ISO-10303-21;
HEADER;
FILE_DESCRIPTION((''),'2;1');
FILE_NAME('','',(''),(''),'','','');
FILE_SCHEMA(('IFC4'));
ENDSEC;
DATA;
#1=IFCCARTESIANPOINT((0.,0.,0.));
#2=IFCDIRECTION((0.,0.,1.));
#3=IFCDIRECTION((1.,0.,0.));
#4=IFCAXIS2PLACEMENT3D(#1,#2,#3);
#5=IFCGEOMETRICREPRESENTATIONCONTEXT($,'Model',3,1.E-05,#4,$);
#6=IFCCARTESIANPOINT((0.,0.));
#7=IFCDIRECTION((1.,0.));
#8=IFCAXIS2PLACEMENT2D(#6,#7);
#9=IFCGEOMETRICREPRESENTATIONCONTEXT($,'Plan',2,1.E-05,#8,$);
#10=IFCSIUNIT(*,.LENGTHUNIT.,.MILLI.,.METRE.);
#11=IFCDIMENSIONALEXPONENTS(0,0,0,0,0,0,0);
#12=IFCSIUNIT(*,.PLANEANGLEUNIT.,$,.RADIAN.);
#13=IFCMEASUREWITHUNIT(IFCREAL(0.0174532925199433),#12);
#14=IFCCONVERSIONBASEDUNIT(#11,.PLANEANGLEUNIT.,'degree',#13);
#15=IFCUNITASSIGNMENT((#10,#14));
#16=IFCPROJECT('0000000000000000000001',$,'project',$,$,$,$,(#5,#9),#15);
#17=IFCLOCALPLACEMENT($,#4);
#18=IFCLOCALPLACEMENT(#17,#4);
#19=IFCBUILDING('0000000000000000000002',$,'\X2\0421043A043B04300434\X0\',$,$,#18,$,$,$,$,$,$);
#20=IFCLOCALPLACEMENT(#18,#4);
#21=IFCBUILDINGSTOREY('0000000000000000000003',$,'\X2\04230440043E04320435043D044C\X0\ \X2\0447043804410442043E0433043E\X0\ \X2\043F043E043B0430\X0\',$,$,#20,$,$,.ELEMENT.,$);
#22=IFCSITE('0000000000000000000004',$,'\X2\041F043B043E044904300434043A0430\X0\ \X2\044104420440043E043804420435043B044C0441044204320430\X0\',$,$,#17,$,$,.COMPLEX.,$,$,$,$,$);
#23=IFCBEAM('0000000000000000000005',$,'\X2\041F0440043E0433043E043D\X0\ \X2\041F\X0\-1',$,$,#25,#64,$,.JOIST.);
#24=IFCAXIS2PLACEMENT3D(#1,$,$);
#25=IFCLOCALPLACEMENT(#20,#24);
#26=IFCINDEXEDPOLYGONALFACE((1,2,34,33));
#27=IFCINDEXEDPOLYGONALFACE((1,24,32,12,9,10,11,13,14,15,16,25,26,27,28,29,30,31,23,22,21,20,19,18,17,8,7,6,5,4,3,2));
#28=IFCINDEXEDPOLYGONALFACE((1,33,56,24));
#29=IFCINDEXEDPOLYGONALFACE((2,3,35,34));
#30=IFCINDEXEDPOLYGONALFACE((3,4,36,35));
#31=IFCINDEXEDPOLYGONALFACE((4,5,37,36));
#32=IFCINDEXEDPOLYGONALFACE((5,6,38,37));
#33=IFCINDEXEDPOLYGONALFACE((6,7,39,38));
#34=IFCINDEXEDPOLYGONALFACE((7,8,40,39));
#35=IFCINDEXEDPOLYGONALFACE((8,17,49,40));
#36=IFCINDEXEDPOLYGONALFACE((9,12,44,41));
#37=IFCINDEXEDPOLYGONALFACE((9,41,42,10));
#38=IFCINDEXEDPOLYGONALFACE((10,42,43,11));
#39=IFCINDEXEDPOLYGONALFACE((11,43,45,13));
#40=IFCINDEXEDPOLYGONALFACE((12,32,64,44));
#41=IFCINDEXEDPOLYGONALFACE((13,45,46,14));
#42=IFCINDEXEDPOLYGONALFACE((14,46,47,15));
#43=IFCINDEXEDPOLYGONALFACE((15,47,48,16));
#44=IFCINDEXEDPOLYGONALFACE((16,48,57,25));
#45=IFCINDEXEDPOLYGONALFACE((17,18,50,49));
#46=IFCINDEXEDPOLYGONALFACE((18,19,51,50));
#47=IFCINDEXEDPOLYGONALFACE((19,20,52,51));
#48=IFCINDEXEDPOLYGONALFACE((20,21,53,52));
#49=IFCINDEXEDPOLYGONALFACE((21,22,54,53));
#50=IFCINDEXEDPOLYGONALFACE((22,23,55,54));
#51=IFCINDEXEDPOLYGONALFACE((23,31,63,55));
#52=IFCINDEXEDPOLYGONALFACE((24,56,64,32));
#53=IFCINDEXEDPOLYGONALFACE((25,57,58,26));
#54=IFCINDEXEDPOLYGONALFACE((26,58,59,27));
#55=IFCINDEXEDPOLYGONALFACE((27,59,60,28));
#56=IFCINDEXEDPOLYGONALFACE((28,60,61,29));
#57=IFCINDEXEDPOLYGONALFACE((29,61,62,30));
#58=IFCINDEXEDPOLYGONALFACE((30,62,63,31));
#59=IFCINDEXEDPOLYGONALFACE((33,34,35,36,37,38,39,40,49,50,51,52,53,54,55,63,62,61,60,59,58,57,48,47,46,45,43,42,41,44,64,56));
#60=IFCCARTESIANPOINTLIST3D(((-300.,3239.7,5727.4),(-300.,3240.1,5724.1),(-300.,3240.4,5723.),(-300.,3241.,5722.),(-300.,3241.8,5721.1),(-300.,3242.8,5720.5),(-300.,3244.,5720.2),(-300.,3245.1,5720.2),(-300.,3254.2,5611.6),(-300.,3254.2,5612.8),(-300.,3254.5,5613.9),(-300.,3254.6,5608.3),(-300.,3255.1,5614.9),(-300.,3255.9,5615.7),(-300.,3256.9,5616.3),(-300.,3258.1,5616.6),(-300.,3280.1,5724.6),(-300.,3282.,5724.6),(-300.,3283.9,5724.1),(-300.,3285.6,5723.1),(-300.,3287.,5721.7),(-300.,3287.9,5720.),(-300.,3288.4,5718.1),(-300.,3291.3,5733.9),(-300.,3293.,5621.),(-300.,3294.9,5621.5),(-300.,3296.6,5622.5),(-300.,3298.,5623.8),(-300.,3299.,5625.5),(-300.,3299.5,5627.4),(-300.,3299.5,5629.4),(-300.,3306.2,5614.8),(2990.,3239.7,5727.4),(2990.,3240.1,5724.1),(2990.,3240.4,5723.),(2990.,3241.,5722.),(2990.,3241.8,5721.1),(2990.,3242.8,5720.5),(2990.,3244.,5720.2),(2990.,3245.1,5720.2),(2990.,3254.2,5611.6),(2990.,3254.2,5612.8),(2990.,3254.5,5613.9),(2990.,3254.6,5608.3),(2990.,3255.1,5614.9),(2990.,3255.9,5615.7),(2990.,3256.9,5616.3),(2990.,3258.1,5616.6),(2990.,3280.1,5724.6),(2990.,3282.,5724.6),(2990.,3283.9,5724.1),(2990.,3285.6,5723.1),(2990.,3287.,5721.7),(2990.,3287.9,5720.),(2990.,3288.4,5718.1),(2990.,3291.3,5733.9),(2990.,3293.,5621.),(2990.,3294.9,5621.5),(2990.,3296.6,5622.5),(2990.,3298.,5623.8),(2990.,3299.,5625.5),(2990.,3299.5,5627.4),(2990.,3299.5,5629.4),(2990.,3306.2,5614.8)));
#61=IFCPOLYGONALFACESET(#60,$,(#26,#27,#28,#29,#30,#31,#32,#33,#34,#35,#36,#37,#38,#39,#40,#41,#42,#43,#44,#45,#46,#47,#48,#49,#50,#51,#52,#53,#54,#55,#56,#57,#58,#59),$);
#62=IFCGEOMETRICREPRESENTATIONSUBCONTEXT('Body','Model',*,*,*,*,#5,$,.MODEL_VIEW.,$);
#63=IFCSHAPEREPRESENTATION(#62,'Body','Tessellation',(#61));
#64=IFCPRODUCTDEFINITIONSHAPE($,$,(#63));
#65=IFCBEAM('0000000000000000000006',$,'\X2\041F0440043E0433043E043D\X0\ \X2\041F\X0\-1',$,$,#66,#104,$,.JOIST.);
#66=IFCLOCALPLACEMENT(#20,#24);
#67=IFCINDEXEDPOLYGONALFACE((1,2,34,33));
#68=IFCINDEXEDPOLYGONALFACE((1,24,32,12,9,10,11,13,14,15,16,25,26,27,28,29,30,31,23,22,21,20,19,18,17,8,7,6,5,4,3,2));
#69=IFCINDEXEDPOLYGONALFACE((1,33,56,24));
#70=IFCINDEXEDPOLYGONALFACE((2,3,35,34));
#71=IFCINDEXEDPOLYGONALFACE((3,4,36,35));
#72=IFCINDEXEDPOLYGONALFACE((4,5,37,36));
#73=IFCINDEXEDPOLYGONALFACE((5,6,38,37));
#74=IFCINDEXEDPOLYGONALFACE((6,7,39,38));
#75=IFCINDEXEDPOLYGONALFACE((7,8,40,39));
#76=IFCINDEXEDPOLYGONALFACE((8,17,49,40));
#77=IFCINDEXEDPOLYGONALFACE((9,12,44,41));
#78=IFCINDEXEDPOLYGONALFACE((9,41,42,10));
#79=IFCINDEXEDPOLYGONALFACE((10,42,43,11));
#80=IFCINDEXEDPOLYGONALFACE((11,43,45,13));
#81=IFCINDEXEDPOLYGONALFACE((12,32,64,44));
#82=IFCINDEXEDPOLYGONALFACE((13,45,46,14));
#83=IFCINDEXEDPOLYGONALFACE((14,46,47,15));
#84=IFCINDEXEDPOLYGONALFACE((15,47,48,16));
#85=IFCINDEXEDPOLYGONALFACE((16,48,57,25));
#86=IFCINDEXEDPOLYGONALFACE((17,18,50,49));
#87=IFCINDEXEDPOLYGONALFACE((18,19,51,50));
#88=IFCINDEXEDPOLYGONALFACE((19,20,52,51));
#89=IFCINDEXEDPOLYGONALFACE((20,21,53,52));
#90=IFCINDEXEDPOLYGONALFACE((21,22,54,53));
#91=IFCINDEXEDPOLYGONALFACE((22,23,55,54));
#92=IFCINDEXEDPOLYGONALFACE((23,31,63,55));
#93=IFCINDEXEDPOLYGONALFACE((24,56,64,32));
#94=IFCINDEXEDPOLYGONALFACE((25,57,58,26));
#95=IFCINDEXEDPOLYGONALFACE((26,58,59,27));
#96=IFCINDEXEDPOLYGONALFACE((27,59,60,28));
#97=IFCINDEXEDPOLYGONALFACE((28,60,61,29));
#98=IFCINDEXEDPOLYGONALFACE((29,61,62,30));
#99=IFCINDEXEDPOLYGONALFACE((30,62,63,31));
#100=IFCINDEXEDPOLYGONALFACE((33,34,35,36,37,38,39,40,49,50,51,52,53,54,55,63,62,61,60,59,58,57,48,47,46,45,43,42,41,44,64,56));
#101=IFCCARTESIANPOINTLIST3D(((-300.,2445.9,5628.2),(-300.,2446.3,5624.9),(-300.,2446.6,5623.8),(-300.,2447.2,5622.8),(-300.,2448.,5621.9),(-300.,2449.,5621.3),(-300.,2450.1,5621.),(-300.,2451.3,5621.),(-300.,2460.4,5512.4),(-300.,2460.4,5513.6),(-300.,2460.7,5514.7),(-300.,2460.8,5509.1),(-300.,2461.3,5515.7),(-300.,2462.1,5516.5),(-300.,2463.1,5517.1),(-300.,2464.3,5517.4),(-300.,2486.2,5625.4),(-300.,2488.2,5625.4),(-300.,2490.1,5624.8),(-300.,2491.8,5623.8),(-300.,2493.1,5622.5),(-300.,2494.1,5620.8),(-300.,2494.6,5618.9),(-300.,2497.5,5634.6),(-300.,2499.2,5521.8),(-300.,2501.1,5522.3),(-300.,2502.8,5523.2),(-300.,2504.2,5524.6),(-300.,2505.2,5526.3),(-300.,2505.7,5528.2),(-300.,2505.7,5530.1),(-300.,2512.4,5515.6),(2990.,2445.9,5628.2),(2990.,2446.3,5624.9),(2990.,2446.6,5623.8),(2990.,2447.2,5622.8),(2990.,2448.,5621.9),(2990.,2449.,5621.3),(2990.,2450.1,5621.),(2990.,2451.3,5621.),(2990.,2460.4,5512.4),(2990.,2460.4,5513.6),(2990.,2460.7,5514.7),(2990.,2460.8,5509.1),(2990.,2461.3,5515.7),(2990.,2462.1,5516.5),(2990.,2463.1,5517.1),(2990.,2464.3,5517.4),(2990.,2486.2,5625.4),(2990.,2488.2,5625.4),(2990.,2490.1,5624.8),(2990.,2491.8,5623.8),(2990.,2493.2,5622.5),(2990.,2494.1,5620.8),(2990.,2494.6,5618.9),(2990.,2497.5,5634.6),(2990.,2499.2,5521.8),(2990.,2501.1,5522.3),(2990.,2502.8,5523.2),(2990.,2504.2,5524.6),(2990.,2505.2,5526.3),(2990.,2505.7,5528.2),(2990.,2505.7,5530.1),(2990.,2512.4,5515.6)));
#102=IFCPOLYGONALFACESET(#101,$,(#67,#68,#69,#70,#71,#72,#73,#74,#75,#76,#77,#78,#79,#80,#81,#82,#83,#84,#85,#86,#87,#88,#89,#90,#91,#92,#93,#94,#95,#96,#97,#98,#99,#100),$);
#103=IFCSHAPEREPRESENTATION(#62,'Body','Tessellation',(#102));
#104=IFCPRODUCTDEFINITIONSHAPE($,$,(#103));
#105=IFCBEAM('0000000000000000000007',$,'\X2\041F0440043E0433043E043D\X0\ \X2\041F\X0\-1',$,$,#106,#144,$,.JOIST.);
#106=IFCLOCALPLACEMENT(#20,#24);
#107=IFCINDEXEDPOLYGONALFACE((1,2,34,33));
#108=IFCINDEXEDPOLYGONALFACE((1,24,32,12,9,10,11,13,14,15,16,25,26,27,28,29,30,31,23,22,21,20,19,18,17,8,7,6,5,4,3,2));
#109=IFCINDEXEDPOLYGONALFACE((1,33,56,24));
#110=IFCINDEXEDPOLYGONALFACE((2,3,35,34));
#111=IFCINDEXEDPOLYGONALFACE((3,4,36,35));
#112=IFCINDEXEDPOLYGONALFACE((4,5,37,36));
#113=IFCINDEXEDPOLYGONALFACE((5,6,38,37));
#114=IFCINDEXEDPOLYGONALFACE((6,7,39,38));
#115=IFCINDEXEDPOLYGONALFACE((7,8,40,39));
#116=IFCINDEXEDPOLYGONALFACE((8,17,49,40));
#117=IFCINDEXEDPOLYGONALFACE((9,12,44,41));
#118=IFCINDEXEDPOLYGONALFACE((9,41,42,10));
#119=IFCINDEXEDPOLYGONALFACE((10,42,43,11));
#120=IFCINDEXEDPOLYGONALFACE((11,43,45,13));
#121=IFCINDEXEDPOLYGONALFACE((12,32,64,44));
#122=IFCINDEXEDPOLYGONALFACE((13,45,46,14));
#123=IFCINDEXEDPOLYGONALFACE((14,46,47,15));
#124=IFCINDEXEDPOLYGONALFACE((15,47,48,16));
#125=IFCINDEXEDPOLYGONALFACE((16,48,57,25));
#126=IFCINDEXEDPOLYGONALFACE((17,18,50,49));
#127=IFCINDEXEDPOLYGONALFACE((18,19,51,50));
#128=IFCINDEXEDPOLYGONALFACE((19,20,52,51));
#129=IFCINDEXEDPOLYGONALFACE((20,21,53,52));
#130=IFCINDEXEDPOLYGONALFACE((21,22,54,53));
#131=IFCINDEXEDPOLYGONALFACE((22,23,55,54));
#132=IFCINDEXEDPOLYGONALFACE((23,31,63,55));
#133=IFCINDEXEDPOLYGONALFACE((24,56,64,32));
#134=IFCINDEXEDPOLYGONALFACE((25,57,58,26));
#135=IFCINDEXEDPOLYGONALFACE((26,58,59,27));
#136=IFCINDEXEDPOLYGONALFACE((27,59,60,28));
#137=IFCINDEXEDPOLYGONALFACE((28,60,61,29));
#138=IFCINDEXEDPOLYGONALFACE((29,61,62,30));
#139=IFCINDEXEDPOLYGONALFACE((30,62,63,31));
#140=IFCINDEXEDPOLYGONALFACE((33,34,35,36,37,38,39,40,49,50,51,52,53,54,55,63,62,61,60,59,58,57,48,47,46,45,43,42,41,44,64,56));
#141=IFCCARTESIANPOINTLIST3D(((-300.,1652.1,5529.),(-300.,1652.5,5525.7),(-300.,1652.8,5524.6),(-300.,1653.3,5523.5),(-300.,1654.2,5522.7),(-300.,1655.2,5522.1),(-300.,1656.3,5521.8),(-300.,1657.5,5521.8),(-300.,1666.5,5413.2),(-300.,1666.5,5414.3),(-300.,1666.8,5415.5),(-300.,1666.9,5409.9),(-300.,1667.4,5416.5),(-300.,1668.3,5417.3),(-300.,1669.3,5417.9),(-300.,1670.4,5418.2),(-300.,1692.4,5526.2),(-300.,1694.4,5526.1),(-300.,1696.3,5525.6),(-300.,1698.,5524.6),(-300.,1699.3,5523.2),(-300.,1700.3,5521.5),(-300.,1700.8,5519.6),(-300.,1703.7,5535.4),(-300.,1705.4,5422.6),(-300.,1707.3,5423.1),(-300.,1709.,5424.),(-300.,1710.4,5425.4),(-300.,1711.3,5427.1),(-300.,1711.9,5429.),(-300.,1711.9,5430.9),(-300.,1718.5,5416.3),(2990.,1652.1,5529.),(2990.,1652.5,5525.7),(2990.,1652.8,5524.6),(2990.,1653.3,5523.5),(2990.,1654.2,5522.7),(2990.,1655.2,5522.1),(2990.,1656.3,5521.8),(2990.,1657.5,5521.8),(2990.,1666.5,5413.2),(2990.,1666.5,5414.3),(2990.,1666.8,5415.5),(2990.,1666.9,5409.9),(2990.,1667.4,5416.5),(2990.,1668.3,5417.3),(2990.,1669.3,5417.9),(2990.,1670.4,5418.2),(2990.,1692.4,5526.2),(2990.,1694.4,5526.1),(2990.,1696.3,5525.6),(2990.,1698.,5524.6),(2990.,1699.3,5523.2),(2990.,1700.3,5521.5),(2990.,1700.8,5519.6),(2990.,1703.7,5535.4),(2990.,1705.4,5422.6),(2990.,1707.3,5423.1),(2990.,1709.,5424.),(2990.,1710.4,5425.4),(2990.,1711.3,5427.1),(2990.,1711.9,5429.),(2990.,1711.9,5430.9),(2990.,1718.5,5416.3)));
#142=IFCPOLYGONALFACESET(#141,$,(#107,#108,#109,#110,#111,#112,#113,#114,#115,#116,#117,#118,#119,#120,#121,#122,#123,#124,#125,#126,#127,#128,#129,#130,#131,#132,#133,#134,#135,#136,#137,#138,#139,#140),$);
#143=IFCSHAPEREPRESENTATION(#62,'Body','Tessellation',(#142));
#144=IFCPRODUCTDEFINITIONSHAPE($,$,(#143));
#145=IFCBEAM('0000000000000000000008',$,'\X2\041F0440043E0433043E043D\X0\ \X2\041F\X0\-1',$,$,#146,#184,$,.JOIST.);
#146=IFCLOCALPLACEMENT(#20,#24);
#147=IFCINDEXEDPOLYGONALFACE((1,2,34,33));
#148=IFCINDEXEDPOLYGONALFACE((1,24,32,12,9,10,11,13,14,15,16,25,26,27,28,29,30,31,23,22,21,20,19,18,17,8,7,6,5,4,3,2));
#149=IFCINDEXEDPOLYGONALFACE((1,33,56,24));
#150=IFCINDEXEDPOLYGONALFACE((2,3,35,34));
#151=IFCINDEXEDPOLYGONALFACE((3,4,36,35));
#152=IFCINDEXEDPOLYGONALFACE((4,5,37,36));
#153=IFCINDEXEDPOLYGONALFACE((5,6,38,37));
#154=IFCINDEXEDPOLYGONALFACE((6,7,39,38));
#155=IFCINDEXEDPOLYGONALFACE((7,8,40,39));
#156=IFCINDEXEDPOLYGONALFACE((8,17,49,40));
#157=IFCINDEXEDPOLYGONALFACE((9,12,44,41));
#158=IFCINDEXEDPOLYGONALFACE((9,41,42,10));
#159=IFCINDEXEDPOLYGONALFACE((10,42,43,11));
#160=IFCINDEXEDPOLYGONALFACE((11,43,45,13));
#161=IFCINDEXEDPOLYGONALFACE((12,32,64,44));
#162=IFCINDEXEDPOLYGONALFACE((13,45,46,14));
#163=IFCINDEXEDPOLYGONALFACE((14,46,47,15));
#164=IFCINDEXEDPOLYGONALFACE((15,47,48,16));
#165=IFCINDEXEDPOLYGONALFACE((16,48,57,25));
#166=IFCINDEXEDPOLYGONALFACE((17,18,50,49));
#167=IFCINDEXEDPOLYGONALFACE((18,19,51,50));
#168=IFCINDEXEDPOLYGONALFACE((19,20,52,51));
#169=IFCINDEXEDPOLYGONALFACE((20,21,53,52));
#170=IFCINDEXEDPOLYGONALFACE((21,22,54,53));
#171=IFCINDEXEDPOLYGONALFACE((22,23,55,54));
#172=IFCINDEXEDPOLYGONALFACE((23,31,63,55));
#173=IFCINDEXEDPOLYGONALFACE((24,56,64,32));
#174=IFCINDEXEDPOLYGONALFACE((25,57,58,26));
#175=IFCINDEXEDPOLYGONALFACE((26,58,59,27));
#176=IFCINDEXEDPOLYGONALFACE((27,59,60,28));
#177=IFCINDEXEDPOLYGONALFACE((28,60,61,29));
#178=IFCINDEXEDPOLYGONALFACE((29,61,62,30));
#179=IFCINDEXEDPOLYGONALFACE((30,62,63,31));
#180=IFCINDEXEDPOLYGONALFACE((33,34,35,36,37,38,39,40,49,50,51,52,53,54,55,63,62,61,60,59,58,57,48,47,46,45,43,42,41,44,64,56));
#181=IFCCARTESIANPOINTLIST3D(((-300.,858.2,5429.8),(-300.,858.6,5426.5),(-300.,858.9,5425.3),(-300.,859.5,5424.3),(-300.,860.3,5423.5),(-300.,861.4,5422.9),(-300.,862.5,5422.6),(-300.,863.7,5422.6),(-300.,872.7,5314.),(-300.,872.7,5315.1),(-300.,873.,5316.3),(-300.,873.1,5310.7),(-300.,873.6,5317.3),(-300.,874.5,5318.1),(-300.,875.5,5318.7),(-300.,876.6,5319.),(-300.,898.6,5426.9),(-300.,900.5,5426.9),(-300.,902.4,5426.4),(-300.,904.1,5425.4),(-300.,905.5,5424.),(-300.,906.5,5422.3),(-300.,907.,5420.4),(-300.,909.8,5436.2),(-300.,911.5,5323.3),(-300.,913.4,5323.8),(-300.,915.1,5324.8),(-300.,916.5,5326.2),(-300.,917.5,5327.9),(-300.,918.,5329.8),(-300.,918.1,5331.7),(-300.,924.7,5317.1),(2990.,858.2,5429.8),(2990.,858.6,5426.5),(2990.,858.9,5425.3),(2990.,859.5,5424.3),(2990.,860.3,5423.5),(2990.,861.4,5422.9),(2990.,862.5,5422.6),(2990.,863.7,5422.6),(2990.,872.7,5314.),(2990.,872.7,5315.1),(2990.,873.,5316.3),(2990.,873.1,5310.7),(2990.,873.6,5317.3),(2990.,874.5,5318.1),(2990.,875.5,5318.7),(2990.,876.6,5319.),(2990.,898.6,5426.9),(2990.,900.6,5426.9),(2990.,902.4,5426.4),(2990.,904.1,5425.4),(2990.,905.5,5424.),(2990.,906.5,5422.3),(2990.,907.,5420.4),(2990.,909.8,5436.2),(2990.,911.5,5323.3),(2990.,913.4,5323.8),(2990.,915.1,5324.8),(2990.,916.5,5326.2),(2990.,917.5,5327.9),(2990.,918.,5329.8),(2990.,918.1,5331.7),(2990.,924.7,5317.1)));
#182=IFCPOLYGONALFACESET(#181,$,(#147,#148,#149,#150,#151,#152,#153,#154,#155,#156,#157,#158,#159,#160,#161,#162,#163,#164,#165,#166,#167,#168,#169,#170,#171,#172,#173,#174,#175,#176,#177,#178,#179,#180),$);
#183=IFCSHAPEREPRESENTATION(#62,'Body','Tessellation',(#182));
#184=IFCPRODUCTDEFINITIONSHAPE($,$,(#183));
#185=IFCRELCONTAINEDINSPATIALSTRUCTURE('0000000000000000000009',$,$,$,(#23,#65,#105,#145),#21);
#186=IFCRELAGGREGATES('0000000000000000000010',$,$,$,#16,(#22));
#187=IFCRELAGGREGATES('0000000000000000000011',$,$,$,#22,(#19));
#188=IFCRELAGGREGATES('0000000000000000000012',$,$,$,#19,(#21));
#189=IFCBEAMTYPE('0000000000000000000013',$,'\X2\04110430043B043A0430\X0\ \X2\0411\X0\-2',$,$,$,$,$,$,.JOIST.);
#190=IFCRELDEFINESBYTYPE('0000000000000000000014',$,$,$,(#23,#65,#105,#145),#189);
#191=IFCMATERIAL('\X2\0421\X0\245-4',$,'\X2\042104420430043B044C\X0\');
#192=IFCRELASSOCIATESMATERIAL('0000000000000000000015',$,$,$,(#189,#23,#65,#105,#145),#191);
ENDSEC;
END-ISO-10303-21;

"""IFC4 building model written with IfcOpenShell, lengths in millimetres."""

from ifc_helpers import new_model, entity, si_unit, converted_unit, frame, origin_with_axes, origin_2d_with_axis, place, context, subcontext, project, spatial, u_section, extrude, material, material_profile, profile_set, profile_usage, type_object, element, save


model = new_model("IFC4")

# Units and contexts
model_context = context("Model", 3, precision=1e-05, world=origin_with_axes())
plan_context = context("Plan", 2, precision=1e-05, world=origin_2d_with_axis())
body_context = subcontext(model_context, "Body", "Model", "MODEL_VIEW")
ifc_project = project(units=[si_unit("LENGTHUNIT", "METRE", prefix="MILLI"), converted_unit("PLANEANGLEUNIT", "degree", entity("IfcReal", 0.0174532925199433), si_unit("PLANEANGLEUNIT", "RADIAN"), dimensions=[0, 0, 0, 0, 0, 0, 0])], contexts=[model_context, plan_context])

# Site, building, storey
site_placement = place(None, origin_with_axes())
site = spatial("IfcSite", under=ifc_project, at=site_placement, Name="Площадка строительства", CompositionType="COMPLEX")
building_placement = place(site_placement, origin_with_axes())
building = spatial("IfcBuilding", under=site, at=building_placement, Name="Склад")
storey_placement = place(building_placement, origin_with_axes())
storey = spatial("IfcBuildingStorey", under=building, at=storey_placement, Name="Уровень чистого пола", CompositionType="ELEMENT")

# Beams
ifc_material_1 = material(Name="С245-4", Category="Сталь")
ifc_material_profile_1 = material_profile(ifc_material_1, u_section(Depth=120.0, FlangeWidth=52.0, WebThickness=4.8, FlangeThickness=7.8, FilletRadius=7.5, EdgeRadius=4.5, FlangeSlope=0.0))
ifc_profile_set_1 = profile_set([ifc_material_profile_1], Name="U12P_S245-4")
ifc_profile_usage_1 = profile_usage(ifc_profile_set_1, cardinal=3)
beam_type_1 = type_object("IfcBeamType", Name="Балка Б-2", PredefinedType="JOIST", material=ifc_profile_set_1)
for number, where, z_axis, x_axis, name in (
    (1, (2990.0, 3306.2, 5614.8), (-1.0, 0.0, 0.0), (0.0, -0.99228, -0.124019), "Прогон П-1"),
    (2, (2990.0, 2512.4, 5515.6), (-1.0, 0.0, 0.0), (0.0, -0.99228, -0.124019), "Прогон П-1"),
    (3, (2990.0, 1718.5, 5416.3), (-1.0, 0.0, 0.0), (0.0, -0.99228, -0.124019), "Прогон П-1"),
    (4, (2990.0, 924.7, 5317.1), (-1.0, 0.0, 0.0), (0.0, -0.99228, -0.124019), "Прогон П-1"),
):
    element("IfcBeam", number, at=place(storey_placement, frame(where, z_axis=z_axis, x_axis=x_axis)), inside=storey, type_object=beam_type_1, material=ifc_profile_usage_1, Name=name, PredefinedType="JOIST", context=body_context, shape_type="SweptSolid", body=[
        extrude(u_section(Depth=120.0, FlangeWidth=52.0, WebThickness=4.8, FlangeThickness=7.8, FilletRadius=7.5, EdgeRadius=4.5, FlangeSlope=0.0), frame((26.0, 60.0, 0.0), z_axis=(0.0, 0.0, 1.0), x_axis=(1.0, 0.0, 0.0)), (0.0, 0.0, 1.0), 3290.0),
    ])

save(model, "model.ifc")
